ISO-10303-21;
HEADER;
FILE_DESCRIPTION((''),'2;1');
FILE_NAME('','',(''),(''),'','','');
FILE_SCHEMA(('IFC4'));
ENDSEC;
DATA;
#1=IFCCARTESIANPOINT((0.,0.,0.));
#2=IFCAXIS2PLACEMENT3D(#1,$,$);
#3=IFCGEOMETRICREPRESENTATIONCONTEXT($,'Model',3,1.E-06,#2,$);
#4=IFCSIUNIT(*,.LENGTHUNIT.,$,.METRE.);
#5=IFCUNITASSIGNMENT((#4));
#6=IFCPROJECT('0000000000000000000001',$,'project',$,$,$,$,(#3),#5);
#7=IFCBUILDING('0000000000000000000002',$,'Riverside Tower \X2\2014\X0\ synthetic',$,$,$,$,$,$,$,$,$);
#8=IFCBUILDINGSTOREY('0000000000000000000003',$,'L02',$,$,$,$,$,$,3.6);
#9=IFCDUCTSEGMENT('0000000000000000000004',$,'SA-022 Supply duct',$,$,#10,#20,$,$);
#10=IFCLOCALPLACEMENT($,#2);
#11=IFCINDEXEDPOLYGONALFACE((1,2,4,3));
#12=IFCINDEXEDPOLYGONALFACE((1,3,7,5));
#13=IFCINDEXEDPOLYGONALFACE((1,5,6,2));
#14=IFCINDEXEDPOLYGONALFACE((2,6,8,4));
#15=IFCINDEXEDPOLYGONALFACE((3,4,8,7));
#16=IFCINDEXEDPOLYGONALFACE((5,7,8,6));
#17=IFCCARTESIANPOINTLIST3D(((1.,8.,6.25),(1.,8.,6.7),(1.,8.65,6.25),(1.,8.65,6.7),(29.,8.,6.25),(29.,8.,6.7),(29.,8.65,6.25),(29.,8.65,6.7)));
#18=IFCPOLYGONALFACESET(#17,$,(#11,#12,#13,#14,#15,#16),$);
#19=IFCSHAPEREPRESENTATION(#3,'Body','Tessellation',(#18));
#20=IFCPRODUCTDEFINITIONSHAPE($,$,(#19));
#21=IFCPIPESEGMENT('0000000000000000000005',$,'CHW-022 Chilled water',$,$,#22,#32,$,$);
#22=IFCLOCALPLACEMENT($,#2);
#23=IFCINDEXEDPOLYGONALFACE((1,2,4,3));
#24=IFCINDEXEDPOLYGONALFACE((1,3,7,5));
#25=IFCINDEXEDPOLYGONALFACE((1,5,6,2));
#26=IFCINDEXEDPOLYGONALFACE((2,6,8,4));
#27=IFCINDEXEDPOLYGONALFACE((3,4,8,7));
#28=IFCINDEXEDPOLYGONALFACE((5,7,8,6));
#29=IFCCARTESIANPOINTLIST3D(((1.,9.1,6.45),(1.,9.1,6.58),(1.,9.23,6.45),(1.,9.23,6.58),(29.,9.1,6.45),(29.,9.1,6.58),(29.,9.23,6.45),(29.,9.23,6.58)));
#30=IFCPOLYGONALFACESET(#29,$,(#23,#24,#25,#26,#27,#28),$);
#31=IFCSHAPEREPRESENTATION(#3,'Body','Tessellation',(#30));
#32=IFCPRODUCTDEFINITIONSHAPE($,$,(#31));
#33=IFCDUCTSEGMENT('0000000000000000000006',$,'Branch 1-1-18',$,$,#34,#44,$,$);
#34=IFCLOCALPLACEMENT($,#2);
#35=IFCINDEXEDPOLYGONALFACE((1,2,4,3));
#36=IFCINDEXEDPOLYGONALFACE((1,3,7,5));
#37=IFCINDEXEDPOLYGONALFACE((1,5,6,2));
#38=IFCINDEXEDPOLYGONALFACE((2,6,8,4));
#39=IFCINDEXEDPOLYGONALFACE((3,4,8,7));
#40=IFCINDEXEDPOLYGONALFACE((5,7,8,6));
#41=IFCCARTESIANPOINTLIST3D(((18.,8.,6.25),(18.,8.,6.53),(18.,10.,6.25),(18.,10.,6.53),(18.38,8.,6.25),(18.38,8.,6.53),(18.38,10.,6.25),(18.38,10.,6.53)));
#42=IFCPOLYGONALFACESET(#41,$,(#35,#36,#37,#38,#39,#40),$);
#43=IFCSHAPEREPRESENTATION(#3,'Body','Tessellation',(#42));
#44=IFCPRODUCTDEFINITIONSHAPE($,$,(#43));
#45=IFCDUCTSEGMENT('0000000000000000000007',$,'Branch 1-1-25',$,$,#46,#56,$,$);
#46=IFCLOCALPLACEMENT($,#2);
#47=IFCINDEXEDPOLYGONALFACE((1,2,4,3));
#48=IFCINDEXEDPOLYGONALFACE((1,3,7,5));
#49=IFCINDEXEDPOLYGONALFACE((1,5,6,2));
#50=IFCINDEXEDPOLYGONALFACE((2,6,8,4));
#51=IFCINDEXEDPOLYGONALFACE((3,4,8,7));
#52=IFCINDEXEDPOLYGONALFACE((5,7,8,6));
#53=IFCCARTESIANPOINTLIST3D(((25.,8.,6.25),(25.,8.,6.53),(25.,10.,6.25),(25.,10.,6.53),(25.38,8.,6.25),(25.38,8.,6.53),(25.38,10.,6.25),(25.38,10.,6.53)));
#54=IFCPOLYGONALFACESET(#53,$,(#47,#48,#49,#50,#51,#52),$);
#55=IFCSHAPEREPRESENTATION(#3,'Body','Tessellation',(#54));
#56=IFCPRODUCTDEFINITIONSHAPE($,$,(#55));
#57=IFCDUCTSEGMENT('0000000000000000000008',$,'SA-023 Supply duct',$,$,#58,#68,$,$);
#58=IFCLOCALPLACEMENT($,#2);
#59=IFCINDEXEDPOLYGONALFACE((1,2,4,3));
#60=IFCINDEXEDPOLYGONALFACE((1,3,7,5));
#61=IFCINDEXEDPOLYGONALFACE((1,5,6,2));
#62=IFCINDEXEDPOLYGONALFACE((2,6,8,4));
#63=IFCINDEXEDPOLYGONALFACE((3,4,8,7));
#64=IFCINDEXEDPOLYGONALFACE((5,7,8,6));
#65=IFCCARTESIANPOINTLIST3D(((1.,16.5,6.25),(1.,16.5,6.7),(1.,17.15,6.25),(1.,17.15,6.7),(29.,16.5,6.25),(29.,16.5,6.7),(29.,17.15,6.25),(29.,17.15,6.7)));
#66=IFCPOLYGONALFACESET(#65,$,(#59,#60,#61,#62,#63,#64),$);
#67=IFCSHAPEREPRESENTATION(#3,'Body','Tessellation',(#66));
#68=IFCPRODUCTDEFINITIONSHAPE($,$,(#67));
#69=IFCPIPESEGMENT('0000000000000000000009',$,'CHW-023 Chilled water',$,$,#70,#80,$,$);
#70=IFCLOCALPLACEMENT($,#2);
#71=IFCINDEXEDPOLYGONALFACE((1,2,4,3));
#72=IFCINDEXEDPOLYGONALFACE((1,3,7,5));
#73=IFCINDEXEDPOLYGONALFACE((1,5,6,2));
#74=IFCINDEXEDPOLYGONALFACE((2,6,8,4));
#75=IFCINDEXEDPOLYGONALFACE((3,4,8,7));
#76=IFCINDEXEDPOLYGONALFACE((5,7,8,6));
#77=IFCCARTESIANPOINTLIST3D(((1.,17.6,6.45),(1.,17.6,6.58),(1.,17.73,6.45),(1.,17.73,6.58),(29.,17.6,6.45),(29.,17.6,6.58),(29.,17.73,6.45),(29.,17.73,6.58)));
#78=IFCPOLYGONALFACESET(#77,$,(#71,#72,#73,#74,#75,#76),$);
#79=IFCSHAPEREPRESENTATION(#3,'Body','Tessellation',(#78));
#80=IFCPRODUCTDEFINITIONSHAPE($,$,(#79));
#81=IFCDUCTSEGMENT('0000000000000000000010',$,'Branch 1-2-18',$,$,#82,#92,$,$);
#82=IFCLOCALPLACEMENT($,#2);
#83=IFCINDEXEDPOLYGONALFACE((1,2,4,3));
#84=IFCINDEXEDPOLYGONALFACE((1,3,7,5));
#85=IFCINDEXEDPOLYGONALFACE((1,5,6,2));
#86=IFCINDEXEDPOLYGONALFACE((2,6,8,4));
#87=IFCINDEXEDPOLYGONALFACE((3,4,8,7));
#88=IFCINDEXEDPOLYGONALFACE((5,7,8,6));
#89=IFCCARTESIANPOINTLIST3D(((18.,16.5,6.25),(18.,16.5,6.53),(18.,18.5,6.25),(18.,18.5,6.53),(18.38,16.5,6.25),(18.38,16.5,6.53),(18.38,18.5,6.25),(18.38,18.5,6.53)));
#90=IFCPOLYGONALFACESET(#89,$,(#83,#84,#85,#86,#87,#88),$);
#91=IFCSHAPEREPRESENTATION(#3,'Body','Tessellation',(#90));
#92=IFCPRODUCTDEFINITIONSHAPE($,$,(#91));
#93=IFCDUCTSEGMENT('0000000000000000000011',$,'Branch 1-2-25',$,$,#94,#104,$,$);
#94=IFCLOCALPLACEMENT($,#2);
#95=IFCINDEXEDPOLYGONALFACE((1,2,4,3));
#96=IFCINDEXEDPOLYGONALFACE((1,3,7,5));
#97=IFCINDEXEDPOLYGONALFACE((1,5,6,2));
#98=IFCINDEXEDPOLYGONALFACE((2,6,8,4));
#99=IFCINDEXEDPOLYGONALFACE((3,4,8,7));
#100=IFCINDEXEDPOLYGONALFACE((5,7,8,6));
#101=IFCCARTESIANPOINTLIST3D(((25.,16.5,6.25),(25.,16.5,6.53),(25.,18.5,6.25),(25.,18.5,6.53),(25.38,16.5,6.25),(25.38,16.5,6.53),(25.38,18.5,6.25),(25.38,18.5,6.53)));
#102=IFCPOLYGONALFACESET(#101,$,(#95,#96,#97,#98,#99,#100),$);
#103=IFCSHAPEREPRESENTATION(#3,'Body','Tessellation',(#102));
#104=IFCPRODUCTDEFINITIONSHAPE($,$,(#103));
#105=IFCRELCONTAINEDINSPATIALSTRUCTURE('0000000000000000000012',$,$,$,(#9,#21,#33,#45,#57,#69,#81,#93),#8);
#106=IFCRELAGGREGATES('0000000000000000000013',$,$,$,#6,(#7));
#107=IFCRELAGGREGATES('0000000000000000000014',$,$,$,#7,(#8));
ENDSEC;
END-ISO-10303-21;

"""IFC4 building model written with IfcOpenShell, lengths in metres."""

from ifc_helpers import new_model, si_unit, frame, origin, place, context, project, spatial, rectangle, extrude, element, save


model = new_model("IFC4")

# Units and contexts
model_context = context("Model", 3, precision=1e-06, world=origin())
ifc_project = project(units=[si_unit("LENGTHUNIT", "METRE")], contexts=[model_context])

# Building, storey
building = spatial("IfcBuilding", under=ifc_project, Name="Riverside Tower — synthetic")
storey = spatial("IfcBuildingStorey", under=building, Name="L02", Elevation=3.6)

# Duct segment
duct_segment_1_placement = place(None, frame((15.0, 8.325, 6.25)))
element("IfcDuctSegment", 1, at=duct_segment_1_placement, inside=storey, Name="SA-022 Supply duct", context=model_context, shape_type="SweptSolid", body=[
    extrude(rectangle(XDim=28.0, YDim=0.65), origin(), (0.0, 0.0, 1.0), 0.45),
])

# Pipe segment
pipe_segment_1_placement = place(None, frame((15.0, 9.165, 6.45)))
element("IfcPipeSegment", 2, at=pipe_segment_1_placement, inside=storey, Name="CHW-022 Chilled water", context=model_context, shape_type="SweptSolid", body=[
    extrude(rectangle(XDim=28.0, YDim=0.13), origin(), (0.0, 0.0, 1.0), 0.13),
])

# Duct segments
for number, where, name in (
    (3, (18.19, 9.0, 6.25), "Branch 1-1-18"),
    (4, (25.19, 9.0, 6.25), "Branch 1-1-25"),
):
    element("IfcDuctSegment", number, at=place(None, frame(where)), inside=storey, Name=name, context=model_context, shape_type="SweptSolid", body=[
        extrude(rectangle(XDim=0.38, YDim=2.0), origin(), (0.0, 0.0, 1.0), 0.28),
    ])
duct_segment_2_placement = place(None, frame((15.0, 16.825, 6.25)))
element("IfcDuctSegment", 5, at=duct_segment_2_placement, inside=storey, Name="SA-023 Supply duct", context=model_context, shape_type="SweptSolid", body=[
    extrude(rectangle(XDim=28.0, YDim=0.65), origin(), (0.0, 0.0, 1.0), 0.45),
])

# Pipe segment
pipe_segment_2_placement = place(None, frame((15.0, 17.665, 6.45)))
element("IfcPipeSegment", 6, at=pipe_segment_2_placement, inside=storey, Name="CHW-023 Chilled water", context=model_context, shape_type="SweptSolid", body=[
    extrude(rectangle(XDim=28.0, YDim=0.13), origin(), (0.0, 0.0, 1.0), 0.13),
])

# Duct segments
for number, where, name in (
    (7, (18.19, 17.5, 6.25), "Branch 1-2-18"),
    (8, (25.19, 17.5, 6.25), "Branch 1-2-25"),
):
    element("IfcDuctSegment", number, at=place(None, frame(where)), inside=storey, Name=name, context=model_context, shape_type="SweptSolid", body=[
        extrude(rectangle(XDim=0.38, YDim=2.0), origin(), (0.0, 0.0, 1.0), 0.28),
    ])

save(model, "model.ifc")
